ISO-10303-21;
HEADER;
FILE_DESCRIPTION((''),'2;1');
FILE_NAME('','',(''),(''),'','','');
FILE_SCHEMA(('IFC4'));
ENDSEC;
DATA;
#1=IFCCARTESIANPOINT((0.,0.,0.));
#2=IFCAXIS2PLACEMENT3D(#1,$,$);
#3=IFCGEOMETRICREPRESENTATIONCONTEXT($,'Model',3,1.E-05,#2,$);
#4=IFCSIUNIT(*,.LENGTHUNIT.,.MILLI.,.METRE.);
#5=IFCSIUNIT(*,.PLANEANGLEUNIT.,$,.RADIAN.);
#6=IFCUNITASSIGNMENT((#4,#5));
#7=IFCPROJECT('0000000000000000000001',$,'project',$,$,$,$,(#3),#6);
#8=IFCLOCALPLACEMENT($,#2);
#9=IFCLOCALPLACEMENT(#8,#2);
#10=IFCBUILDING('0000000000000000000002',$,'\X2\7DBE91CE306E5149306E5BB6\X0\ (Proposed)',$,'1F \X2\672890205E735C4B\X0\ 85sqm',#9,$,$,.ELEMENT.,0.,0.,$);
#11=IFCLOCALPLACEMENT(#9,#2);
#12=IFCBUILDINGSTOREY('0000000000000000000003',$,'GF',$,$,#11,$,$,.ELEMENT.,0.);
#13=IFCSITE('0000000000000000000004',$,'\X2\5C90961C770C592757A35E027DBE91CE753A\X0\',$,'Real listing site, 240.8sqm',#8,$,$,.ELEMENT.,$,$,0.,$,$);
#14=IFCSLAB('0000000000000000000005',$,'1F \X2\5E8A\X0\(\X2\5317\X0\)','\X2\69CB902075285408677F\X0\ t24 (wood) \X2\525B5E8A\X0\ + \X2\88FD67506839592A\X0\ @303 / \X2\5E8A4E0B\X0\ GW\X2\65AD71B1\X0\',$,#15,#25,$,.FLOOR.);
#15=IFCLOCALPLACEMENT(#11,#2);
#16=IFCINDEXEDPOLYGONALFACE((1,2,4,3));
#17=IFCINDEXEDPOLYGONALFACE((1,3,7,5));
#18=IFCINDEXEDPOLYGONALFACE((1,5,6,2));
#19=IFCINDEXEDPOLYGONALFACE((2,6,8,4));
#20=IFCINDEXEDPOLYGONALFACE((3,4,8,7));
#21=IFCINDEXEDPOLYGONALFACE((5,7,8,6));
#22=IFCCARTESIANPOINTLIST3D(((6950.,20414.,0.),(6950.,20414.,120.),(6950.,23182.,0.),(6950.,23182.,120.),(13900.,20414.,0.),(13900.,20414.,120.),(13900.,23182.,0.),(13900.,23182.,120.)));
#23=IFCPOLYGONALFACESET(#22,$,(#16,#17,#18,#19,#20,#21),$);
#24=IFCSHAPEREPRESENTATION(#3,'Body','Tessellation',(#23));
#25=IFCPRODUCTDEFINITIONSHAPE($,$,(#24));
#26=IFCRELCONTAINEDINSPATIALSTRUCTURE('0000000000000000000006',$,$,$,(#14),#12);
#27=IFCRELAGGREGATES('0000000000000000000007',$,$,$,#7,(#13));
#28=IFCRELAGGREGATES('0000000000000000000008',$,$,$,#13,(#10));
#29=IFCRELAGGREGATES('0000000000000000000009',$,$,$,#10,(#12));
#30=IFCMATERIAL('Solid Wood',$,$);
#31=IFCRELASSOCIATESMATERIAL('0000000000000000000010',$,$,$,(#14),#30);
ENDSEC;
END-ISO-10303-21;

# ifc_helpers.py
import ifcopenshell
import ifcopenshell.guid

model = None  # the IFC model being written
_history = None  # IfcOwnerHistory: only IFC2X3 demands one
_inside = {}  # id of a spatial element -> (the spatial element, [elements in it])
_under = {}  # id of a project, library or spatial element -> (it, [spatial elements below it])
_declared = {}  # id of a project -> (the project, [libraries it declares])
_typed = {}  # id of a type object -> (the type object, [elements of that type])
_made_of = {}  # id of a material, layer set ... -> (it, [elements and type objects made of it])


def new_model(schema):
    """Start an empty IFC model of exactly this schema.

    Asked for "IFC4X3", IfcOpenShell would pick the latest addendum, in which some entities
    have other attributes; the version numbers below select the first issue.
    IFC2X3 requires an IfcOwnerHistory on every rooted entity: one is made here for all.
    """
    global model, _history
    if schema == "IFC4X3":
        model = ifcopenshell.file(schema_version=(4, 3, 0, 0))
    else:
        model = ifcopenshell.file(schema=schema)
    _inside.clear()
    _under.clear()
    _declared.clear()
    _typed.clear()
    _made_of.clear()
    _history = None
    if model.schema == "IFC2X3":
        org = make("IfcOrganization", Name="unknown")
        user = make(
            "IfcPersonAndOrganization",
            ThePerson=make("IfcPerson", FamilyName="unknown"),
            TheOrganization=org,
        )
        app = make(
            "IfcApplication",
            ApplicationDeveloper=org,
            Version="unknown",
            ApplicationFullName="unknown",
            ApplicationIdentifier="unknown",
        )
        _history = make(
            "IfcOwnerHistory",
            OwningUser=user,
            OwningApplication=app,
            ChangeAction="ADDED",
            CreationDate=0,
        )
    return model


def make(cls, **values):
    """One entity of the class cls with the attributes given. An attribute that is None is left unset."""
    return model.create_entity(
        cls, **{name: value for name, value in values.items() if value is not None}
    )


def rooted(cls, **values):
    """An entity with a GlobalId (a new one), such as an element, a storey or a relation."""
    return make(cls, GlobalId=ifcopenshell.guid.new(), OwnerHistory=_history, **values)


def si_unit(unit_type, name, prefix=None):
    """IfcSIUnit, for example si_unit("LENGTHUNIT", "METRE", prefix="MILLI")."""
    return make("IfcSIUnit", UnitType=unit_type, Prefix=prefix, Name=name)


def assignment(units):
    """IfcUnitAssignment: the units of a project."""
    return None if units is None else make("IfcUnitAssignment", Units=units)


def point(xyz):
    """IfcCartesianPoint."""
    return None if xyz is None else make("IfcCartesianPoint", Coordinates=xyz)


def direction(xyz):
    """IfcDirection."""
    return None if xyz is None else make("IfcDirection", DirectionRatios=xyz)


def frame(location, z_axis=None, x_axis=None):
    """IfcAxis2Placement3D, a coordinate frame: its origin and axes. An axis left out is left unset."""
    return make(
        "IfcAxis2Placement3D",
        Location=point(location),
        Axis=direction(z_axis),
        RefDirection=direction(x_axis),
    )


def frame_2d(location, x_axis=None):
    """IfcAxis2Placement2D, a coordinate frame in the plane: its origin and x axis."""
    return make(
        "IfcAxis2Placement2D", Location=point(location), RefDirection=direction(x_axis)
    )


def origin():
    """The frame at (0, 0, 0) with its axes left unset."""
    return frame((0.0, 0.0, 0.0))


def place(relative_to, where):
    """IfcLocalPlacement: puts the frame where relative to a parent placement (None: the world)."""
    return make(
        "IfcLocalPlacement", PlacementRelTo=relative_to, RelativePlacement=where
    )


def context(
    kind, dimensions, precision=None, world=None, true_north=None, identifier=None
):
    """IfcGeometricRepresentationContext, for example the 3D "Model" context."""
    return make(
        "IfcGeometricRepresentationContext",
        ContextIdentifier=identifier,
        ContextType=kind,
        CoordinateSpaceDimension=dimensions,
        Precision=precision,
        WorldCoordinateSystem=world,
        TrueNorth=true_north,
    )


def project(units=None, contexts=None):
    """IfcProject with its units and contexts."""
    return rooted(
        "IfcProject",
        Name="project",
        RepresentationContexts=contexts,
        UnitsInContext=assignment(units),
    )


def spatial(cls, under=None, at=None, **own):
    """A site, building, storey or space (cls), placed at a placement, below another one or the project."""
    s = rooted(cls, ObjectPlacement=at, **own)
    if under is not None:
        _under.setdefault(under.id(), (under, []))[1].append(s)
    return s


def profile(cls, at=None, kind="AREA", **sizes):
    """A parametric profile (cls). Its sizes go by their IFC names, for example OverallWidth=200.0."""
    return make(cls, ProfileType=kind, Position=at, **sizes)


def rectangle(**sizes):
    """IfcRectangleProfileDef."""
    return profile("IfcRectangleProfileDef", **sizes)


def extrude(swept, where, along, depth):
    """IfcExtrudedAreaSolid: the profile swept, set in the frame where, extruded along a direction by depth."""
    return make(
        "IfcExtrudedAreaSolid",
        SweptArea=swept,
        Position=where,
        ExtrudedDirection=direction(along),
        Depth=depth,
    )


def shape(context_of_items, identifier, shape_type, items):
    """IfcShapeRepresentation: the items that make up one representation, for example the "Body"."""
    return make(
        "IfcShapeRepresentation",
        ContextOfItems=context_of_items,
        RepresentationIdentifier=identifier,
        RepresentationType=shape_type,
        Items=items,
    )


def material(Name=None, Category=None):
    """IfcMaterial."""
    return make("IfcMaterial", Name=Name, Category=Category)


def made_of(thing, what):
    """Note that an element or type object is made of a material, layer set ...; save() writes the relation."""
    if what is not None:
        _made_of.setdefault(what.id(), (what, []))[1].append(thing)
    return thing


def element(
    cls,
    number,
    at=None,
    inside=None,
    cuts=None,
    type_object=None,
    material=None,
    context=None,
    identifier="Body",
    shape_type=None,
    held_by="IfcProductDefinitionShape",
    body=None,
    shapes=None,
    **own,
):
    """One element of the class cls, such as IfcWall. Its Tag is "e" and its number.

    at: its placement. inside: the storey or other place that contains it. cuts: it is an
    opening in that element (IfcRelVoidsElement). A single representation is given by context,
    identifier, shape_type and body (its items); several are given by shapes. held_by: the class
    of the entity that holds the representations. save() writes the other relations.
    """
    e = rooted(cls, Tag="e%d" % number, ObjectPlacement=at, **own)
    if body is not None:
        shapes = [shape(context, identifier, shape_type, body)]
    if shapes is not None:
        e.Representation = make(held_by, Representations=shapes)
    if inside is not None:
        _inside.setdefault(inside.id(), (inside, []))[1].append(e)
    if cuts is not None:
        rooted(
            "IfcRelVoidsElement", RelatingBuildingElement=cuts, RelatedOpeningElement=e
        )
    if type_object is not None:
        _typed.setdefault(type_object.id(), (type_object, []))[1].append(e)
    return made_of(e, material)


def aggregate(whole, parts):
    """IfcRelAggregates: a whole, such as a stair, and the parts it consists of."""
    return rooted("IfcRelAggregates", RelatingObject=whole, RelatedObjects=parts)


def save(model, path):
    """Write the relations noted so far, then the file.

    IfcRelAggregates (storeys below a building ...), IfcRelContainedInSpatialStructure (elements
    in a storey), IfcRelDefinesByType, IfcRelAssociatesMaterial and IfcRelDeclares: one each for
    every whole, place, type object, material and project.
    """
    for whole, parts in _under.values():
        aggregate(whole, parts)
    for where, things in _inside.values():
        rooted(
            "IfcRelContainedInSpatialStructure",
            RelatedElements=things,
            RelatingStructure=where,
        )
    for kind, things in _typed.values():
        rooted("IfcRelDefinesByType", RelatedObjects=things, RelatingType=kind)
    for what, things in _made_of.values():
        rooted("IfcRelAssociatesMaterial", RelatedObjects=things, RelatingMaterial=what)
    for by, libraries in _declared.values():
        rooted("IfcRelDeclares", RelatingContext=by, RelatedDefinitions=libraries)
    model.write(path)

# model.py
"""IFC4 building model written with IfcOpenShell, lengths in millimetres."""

from ifc_helpers import new_model, si_unit, frame, frame_2d, origin, place, context, project, spatial, rectangle, extrude, material, element, save


model = new_model("IFC4")

# Units and contexts
model_context = context("Model", 3, precision=1e-05, world=origin())
ifc_project = project(units=[si_unit("LENGTHUNIT", "METRE", prefix="MILLI"), si_unit("PLANEANGLEUNIT", "RADIAN")], contexts=[model_context])

# Site, building, storey
site_placement = place(None, origin())
site = spatial("IfcSite", under=ifc_project, at=site_placement, Name="岐阜県大垣市綾野町", ObjectType="Real listing site, 240.8sqm", CompositionType="ELEMENT", RefElevation=0.0)
building_placement = place(site_placement, origin())
building = spatial("IfcBuilding", under=site, at=building_placement, Name="綾野の光の家 (Proposed)", ObjectType="1F 木造平屋 85sqm", CompositionType="ELEMENT", ElevationOfRefHeight=0.0, ElevationOfTerrain=0.0)
storey_placement = place(building_placement, origin())
storey = spatial("IfcBuildingStorey", under=building, at=storey_placement, Name="GF", CompositionType="ELEMENT", Elevation=0.0)

# Slab
ifc_material_1 = material(Name="Solid Wood")
slab_1_placement = place(storey_placement, frame((3475.0, 10207.0, 0.0)))
element("IfcSlab", 1, at=slab_1_placement, inside=storey, material=ifc_material_1, Name="1F 床(北)", Description="構造用合板 t24 (wood) 剛床 + 製材根太 @303 / 床下 GW断熱", PredefinedType="FLOOR", context=model_context, shape_type="SweptSolid", body=[
    extrude(rectangle(XDim=6950.0, YDim=2768.0, at=frame_2d((3475.0, 1384.0))), frame((3475.0, 10207.0, 0.0)), (0.0, 0.0, 1.0), 120.0),
])

save(model, "model.ifc")
